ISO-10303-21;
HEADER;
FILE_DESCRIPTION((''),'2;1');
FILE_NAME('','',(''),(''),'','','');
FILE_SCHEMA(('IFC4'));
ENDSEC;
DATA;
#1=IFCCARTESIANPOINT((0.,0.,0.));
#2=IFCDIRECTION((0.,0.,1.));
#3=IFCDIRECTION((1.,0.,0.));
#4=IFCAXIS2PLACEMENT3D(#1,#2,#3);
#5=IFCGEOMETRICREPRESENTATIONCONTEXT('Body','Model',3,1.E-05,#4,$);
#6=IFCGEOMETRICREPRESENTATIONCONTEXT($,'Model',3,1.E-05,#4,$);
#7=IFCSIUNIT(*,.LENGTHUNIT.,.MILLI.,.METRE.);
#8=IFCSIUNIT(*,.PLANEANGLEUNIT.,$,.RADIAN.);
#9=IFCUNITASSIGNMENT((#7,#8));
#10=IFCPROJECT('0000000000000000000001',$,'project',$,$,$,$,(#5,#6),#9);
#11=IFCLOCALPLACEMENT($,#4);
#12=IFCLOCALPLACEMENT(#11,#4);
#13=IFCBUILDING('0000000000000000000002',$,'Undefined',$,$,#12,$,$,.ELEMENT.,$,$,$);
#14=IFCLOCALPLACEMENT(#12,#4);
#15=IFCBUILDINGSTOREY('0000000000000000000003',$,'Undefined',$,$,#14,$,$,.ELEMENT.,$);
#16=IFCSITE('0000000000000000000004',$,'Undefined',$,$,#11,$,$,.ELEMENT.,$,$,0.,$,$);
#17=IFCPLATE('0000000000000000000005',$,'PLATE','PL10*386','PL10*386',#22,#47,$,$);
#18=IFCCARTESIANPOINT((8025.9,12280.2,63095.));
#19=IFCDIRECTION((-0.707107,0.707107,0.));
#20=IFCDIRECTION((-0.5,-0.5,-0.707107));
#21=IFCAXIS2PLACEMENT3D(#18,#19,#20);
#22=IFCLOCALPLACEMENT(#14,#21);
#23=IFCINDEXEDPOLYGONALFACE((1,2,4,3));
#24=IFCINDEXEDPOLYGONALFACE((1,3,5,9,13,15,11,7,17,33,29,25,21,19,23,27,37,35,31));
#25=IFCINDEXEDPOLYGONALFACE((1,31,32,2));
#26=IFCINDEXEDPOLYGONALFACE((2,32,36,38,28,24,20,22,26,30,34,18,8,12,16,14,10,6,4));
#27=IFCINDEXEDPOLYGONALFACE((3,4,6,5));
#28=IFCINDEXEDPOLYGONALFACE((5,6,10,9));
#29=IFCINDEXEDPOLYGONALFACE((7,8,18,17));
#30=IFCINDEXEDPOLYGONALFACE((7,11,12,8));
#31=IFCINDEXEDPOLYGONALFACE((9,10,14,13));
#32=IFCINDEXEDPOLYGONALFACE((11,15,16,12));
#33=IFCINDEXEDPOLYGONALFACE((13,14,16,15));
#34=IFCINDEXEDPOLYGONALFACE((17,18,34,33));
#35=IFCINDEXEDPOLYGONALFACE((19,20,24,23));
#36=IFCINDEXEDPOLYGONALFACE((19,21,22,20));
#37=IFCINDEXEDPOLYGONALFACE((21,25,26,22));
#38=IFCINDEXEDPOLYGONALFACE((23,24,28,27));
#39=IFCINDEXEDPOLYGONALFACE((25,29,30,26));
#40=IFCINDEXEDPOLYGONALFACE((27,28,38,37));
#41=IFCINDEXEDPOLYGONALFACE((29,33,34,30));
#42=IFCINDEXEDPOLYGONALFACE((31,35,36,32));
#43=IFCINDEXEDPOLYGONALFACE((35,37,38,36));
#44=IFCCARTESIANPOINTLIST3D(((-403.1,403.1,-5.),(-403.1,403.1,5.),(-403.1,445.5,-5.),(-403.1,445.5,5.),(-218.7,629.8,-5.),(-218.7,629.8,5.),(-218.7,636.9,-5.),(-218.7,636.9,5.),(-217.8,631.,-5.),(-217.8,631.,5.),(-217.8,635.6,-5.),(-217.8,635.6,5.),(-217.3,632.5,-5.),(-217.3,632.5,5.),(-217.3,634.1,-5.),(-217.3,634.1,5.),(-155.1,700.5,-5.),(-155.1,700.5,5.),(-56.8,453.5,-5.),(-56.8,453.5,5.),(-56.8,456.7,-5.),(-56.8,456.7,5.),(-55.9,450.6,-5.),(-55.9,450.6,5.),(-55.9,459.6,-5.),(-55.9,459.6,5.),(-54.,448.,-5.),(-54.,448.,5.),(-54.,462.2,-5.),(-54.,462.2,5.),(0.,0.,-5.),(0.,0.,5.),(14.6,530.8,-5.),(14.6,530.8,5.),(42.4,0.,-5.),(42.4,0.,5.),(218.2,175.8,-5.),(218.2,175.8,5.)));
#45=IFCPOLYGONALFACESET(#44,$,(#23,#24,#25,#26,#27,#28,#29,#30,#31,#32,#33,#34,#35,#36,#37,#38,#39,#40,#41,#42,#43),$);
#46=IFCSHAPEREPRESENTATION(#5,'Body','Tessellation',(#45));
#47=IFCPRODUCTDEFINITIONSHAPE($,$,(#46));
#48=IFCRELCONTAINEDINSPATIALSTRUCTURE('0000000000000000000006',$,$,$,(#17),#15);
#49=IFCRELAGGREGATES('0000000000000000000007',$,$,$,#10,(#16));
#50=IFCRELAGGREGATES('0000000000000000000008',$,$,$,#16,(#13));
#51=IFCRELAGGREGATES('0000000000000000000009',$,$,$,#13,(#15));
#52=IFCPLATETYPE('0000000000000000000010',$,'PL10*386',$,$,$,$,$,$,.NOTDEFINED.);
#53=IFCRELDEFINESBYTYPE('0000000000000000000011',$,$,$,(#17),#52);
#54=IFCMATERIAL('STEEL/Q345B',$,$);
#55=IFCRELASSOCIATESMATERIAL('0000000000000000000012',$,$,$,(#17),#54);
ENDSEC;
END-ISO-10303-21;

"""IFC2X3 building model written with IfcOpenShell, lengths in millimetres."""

from ifc_helpers import new_model, si_unit, frame, origin_with_axes, place, context, project, spatial, polyline, outline, extrude, material, type_object, element, save


model = new_model("IFC2X3")

# Units and contexts
model_context_1 = context("Model", 3, precision=1e-05, world=origin_with_axes(), identifier="Body")
model_context_2 = context("Model", 3, precision=1e-05, world=origin_with_axes())
ifc_project = project(units=[si_unit("LENGTHUNIT", "METRE", prefix="MILLI"), si_unit("PLANEANGLEUNIT", "RADIAN")], contexts=[model_context_1, model_context_2])

# Site, building, storey
site_placement = place(None, origin_with_axes())
site = spatial("IfcSite", under=ifc_project, at=site_placement, Name="Undefined", CompositionType="ELEMENT", RefElevation=0.0)
building_placement = place(site_placement, origin_with_axes())
building = spatial("IfcBuilding", under=site, at=building_placement, Name="Undefined", CompositionType="ELEMENT")
storey_placement = place(building_placement, origin_with_axes())
storey = spatial("IfcBuildingStorey", under=building, at=storey_placement, Name="Undefined", CompositionType="ELEMENT")

# Shared definitions
ifc_material_1 = material(Name="STEEL/Q345B")

# Plate
plate_type_1 = type_object("IfcPlateType", Name="PL10*386", PredefinedType="NOTDEFINED")
plate_1_placement = place(storey_placement, frame((8025.9, 12280.2, 63095.0), z_axis=(-0.707107, 0.707107, 0.0), x_axis=(-0.5, -0.5, -0.707107)))
element("IfcPlate", 1, at=plate_1_placement, inside=storey, type_object=plate_type_1, material=ifc_material_1, Name="PLATE", Description="PL10*386", ObjectType="PL10*386", context=model_context_1, shape_type="SweptSolid", body=[
    extrude(outline(polyline([(0.0, 0.0), (42.4, 0.0), (218.2, 175.8), (-54.0, 448.0), (-55.9, 450.6), (-56.8, 453.5), (-56.8, 456.7), (-55.9, 459.6), (-54.0, 462.2), (14.6, 530.8), (-155.1, 700.5), (-218.7, 636.9), (-217.8, 635.6), (-217.3, 634.1), (-217.3, 632.5), (-217.8, 631.0), (-218.7, 629.8), (-403.1, 445.5), (-403.1, 403.1), (0.0, 0.0)])), frame((0.0, 0.0, -5.0), z_axis=(0.0, 0.0, 1.0), x_axis=(1.0, 0.0, 0.0)), (0.0, 0.0, 1.0), 10.0),
])

save(model, "model.ifc")
